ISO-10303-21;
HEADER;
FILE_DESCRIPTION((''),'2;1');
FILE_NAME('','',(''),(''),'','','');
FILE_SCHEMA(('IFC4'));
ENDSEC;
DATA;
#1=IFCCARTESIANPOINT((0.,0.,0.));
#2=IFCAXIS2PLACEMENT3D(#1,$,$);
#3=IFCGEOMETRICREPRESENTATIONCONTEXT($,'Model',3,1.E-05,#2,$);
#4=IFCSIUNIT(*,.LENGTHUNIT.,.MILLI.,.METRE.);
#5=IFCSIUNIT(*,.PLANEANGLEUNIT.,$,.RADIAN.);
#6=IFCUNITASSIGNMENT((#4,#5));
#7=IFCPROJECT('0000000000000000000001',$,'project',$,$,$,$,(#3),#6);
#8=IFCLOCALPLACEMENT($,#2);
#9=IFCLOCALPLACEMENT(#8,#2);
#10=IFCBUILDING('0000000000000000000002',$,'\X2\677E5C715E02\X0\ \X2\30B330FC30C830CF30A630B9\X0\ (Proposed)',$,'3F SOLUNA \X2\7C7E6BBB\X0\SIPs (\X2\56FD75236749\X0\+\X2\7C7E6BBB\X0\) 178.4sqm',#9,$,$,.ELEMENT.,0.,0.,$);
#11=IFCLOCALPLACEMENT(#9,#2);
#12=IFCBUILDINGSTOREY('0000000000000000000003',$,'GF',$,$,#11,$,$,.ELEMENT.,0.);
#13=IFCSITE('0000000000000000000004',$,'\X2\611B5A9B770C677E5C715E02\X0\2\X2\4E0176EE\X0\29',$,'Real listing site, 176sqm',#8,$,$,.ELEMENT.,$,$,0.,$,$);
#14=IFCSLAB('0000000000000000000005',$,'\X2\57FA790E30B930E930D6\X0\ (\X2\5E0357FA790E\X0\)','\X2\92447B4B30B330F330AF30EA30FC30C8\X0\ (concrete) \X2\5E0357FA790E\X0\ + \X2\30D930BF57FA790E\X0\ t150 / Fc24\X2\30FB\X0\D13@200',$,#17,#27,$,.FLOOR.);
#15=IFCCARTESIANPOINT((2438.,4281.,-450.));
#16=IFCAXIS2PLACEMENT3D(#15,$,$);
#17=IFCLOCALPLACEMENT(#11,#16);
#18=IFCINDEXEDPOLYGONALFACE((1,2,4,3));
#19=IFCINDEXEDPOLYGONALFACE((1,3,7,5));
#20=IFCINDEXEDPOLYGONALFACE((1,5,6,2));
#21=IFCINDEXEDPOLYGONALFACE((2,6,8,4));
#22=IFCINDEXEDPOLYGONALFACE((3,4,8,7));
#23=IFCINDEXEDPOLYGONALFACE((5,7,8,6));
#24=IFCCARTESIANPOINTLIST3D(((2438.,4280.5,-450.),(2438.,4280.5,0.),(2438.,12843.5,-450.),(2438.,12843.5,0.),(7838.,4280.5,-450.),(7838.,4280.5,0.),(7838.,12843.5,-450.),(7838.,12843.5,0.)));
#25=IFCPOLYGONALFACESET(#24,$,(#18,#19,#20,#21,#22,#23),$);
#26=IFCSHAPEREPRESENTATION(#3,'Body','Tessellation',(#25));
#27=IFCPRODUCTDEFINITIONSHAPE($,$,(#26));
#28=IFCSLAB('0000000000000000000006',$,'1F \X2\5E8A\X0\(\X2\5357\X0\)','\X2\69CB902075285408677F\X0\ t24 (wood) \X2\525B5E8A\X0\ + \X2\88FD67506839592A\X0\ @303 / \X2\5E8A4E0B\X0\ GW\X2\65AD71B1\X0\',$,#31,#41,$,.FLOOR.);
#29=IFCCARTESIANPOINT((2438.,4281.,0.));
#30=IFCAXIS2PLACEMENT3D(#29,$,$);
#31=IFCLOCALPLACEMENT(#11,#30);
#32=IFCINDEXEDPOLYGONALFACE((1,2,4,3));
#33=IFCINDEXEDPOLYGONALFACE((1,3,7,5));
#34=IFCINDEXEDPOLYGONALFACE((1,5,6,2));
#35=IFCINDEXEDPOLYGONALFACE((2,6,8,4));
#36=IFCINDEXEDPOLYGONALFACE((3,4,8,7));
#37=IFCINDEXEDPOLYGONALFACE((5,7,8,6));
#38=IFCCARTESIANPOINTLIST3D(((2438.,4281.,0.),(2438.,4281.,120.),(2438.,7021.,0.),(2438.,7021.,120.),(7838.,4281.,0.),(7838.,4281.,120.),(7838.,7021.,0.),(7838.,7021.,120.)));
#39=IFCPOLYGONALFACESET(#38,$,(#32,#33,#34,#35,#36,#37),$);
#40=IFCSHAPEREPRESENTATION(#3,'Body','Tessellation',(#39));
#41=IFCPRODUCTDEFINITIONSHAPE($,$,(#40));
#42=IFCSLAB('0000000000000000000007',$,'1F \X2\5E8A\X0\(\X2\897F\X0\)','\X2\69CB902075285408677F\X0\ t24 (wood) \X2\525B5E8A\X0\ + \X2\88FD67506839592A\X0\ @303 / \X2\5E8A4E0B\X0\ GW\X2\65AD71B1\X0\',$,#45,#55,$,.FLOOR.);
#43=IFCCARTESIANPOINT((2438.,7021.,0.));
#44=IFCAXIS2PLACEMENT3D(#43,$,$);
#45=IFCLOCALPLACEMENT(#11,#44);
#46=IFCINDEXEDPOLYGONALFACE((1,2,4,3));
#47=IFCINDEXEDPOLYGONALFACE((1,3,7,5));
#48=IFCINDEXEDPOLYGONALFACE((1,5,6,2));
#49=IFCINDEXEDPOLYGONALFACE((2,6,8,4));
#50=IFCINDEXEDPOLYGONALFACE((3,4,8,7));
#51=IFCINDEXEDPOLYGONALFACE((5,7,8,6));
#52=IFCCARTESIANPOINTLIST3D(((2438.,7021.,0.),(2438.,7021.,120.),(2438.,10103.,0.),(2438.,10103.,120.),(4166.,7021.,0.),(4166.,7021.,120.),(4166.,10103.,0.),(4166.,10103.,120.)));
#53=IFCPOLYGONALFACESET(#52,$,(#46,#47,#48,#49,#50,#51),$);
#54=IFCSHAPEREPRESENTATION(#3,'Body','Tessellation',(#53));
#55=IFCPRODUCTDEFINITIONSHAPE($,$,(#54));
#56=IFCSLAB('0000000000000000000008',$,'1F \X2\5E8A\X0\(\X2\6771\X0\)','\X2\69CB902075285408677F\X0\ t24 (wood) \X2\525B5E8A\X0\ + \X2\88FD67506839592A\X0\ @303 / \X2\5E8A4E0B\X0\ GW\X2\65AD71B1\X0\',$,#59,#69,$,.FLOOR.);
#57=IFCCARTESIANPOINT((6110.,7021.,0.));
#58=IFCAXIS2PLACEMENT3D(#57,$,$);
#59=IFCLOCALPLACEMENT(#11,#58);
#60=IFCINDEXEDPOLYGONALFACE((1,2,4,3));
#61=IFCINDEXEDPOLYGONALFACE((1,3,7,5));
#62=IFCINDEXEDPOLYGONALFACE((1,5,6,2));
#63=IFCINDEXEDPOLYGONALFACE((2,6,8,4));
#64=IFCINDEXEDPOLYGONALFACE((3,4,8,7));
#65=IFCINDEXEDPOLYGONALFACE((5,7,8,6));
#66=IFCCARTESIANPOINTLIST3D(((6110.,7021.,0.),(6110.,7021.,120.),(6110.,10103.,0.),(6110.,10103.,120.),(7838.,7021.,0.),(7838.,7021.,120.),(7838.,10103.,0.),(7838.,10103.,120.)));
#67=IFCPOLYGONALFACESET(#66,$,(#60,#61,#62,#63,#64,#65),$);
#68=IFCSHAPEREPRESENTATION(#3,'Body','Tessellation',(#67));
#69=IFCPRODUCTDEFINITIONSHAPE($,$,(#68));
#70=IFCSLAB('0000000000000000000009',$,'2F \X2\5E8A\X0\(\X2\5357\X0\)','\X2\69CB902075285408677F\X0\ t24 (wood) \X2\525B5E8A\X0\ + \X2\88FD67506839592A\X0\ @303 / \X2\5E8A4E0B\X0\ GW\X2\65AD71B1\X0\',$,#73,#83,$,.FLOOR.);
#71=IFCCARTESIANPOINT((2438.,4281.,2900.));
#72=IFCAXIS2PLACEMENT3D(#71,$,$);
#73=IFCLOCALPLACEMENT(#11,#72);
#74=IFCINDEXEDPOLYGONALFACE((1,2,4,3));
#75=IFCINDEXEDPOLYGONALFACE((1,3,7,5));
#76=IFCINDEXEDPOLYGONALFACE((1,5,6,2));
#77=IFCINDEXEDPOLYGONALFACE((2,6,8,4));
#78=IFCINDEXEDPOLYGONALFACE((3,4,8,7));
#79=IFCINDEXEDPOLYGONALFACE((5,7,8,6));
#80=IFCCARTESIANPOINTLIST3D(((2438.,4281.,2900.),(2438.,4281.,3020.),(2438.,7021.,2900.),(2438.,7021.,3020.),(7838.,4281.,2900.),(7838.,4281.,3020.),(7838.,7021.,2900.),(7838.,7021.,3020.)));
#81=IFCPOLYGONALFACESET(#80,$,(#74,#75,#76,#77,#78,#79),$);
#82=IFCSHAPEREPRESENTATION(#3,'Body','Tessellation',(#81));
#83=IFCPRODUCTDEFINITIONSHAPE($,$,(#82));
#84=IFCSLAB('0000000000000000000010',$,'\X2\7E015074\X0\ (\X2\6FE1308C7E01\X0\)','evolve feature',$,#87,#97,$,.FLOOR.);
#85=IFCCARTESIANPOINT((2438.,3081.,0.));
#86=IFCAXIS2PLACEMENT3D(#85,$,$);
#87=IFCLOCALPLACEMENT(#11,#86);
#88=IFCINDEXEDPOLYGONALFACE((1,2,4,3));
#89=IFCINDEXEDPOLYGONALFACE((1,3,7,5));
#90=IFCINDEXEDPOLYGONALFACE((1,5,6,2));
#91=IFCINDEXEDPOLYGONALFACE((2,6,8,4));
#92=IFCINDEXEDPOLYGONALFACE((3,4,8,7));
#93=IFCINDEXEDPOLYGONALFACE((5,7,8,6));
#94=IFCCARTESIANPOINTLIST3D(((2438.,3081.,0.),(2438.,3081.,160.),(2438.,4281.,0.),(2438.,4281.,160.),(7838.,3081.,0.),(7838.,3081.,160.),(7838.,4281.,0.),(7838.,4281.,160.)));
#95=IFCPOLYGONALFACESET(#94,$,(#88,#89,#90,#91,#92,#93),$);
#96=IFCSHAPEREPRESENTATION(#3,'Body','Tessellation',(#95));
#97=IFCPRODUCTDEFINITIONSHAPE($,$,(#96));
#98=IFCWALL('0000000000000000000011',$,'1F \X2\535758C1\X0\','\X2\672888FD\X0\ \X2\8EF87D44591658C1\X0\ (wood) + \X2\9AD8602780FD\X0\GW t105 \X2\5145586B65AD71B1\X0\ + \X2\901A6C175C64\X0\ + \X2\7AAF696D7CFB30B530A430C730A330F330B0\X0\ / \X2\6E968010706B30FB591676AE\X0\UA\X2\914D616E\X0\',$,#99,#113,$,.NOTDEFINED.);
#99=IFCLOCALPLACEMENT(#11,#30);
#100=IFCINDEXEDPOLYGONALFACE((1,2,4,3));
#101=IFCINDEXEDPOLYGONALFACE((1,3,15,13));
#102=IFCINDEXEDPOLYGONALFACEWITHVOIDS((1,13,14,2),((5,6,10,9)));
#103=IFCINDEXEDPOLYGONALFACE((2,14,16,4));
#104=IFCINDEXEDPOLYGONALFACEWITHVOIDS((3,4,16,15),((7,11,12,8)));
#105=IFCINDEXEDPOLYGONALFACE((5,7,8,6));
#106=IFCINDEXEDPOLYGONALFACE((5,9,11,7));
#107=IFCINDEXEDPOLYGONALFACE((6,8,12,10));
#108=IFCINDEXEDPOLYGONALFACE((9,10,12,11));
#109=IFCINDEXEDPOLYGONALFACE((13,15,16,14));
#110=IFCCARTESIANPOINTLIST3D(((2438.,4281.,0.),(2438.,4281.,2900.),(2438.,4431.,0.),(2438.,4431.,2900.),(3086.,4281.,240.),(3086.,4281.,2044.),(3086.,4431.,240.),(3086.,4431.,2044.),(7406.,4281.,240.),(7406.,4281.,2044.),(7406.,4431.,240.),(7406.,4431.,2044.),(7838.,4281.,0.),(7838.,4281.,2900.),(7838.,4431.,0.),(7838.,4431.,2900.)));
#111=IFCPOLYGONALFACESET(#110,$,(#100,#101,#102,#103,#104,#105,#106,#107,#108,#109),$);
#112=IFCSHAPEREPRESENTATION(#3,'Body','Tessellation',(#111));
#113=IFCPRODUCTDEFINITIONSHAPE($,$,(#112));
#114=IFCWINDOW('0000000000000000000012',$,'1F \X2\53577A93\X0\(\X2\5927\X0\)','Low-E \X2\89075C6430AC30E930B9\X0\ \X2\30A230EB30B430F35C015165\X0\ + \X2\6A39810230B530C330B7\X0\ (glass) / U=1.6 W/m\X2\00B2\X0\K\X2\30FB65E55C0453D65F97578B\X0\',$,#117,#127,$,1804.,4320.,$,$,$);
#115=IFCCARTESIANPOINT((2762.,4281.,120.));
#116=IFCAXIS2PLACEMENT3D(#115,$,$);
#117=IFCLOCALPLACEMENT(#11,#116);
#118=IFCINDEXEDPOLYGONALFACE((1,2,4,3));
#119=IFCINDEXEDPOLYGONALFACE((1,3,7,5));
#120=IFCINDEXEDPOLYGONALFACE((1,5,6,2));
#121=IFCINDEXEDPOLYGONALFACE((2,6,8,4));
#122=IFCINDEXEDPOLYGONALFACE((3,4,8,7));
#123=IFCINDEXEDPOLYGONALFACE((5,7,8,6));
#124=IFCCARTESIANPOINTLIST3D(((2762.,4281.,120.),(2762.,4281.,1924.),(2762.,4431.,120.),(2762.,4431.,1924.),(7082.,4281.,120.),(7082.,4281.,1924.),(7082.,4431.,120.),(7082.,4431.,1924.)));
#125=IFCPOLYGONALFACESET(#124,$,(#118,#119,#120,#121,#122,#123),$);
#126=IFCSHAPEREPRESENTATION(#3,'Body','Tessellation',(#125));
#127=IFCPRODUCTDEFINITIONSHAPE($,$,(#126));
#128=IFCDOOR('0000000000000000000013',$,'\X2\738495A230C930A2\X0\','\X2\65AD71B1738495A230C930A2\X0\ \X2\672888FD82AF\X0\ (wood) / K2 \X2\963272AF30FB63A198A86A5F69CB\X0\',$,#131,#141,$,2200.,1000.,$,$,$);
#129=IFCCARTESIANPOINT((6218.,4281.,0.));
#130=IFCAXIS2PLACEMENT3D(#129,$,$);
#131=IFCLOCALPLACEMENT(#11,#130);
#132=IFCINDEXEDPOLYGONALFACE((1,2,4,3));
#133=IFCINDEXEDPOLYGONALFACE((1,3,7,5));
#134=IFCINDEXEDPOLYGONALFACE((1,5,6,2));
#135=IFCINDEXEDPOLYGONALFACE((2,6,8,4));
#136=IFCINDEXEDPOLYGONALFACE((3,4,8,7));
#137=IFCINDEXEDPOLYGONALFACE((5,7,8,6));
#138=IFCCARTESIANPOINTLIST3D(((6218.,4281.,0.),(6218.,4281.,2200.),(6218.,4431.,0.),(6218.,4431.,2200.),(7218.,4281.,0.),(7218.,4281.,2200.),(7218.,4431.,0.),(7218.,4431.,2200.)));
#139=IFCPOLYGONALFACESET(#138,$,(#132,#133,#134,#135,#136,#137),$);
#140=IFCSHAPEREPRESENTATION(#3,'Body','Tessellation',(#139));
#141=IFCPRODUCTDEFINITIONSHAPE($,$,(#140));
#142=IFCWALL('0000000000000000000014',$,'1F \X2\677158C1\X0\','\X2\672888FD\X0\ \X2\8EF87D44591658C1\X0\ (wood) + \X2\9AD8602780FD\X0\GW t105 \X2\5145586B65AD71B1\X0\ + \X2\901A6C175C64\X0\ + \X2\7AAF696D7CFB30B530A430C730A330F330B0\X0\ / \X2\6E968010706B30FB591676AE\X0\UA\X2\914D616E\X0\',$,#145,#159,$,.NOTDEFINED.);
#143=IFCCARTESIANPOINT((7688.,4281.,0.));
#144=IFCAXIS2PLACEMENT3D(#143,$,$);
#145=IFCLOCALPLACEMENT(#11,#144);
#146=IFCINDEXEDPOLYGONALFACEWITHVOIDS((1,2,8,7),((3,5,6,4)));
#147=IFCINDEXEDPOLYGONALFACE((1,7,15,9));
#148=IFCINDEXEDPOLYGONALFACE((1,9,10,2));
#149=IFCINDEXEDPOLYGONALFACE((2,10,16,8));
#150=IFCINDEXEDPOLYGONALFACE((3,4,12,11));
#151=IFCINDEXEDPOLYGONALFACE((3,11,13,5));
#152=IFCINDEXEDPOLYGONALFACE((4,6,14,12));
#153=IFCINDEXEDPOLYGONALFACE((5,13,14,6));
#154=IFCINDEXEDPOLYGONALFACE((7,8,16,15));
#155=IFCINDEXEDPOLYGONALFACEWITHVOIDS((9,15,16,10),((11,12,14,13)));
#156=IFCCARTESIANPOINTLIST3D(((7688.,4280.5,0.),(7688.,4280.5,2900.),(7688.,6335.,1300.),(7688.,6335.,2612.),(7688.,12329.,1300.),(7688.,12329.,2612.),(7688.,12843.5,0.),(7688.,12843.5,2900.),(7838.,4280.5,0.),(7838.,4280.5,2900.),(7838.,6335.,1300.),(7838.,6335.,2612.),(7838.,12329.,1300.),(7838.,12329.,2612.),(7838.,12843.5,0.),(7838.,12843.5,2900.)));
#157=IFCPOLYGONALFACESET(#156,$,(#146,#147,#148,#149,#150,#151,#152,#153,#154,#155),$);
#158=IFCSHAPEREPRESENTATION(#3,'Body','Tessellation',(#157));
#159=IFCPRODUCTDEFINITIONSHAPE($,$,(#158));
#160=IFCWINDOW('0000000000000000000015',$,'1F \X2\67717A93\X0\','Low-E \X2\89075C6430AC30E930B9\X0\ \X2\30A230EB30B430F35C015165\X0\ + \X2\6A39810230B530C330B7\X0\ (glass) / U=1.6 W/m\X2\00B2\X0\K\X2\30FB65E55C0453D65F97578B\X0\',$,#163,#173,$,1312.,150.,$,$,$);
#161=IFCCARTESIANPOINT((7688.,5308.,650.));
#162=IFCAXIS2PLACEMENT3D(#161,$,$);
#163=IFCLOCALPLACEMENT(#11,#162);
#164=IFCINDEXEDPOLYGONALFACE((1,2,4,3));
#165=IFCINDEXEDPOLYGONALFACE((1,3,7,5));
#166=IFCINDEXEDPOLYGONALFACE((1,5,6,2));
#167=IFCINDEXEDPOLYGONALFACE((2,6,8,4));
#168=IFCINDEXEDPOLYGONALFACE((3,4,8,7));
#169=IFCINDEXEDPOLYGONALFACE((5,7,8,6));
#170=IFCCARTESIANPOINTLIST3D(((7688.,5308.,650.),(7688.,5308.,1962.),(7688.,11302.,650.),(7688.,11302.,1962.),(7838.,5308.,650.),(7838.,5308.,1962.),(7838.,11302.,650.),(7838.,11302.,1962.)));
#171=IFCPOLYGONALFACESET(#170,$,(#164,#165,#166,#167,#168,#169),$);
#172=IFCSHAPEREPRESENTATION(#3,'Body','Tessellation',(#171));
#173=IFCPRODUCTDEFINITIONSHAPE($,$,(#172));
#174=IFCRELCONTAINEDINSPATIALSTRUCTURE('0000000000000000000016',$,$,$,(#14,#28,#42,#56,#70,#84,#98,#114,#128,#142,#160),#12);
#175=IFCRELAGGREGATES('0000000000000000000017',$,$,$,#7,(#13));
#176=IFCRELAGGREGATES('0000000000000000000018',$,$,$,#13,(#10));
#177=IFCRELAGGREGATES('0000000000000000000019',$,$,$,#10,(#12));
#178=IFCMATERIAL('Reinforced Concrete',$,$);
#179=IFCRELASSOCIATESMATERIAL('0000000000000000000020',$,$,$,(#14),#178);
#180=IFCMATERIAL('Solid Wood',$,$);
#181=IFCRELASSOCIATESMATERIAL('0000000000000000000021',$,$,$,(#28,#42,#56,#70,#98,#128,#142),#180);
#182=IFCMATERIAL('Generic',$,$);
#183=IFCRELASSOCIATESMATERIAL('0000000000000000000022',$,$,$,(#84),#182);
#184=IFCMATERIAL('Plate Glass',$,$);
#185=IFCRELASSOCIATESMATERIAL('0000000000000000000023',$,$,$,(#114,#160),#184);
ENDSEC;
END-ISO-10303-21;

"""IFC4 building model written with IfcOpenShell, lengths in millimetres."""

from ifc_helpers import new_model, si_unit, frame, frame_2d, origin, place, context, project, spatial, rectangle, extrude, material, element, fill, save


model = new_model("IFC4")

# Units and contexts
model_context = context("Model", 3, precision=1e-05, world=origin())
ifc_project = project(units=[si_unit("LENGTHUNIT", "METRE", prefix="MILLI"), si_unit("PLANEANGLEUNIT", "RADIAN")], contexts=[model_context])

# Site, building, storey
site_placement = place(None, origin())
site = spatial("IfcSite", under=ifc_project, at=site_placement, Name="愛媛県松山市2丁目29", ObjectType="Real listing site, 176sqm", CompositionType="ELEMENT", RefElevation=0.0)
building_placement = place(site_placement, origin())
building = spatial("IfcBuilding", under=site, at=building_placement, Name="松山市 コートハウス (Proposed)", ObjectType="3F SOLUNA 籾殻SIPs (国産杉+籾殻) 178.4sqm", CompositionType="ELEMENT", ElevationOfRefHeight=0.0, ElevationOfTerrain=0.0)
storey_placement = place(building_placement, origin())
storey = spatial("IfcBuildingStorey", under=building, at=storey_placement, Name="GF", CompositionType="ELEMENT", Elevation=0.0)

# Slabs
ifc_material_1 = material(Name="Reinforced Concrete")
slab_1_placement = place(storey_placement, frame((2438.0, 4281.0, -450.0)))
element("IfcSlab", 1, at=slab_1_placement, inside=storey, material=ifc_material_1, Name="基礎スラブ (布基礎)", Description="鉄筋コンクリート (concrete) 布基礎 + ベタ基礎 t150 / Fc24・D13@200", PredefinedType="FLOOR", context=model_context, shape_type="SweptSolid", body=[
    extrude(rectangle(XDim=5400.0, YDim=8563.0, at=frame_2d((2700.0, 4281.0))), frame((2438.0, 4281.0, -450.0)), (0.0, 0.0, 1.0), 450.0),
])
ifc_material_2 = material(Name="Solid Wood")
slab_2_placement = place(storey_placement, frame((2438.0, 4281.0, 0.0)))
element("IfcSlab", 2, at=slab_2_placement, inside=storey, material=ifc_material_2, Name="1F 床(南)", Description="構造用合板 t24 (wood) 剛床 + 製材根太 @303 / 床下 GW断熱", PredefinedType="FLOOR", context=model_context, shape_type="SweptSolid", body=[
    extrude(rectangle(XDim=5400.0, YDim=2740.0, at=frame_2d((2700.0, 1370.0))), frame((2438.0, 4281.0, 0.0)), (0.0, 0.0, 1.0), 120.0),
])
slab_3_placement = place(storey_placement, frame((2438.0, 7021.0, 0.0)))
element("IfcSlab", 3, at=slab_3_placement, inside=storey, material=ifc_material_2, Name="1F 床(西)", Description="構造用合板 t24 (wood) 剛床 + 製材根太 @303 / 床下 GW断熱", PredefinedType="FLOOR", context=model_context, shape_type="SweptSolid", body=[
    extrude(rectangle(XDim=1728.0, YDim=3082.0, at=frame_2d((864.0, 1541.0))), frame((2438.0, 7021.0, 0.0)), (0.0, 0.0, 1.0), 120.0),
])
slab_4_placement = place(storey_placement, frame((6110.0, 7021.0, 0.0)))
element("IfcSlab", 4, at=slab_4_placement, inside=storey, material=ifc_material_2, Name="1F 床(東)", Description="構造用合板 t24 (wood) 剛床 + 製材根太 @303 / 床下 GW断熱", PredefinedType="FLOOR", context=model_context, shape_type="SweptSolid", body=[
    extrude(rectangle(XDim=1728.0, YDim=3082.0, at=frame_2d((864.0, 1541.0))), frame((6110.0, 7021.0, 0.0)), (0.0, 0.0, 1.0), 120.0),
])
slab_5_placement = place(storey_placement, frame((2438.0, 4281.0, 2900.0)))
element("IfcSlab", 5, at=slab_5_placement, inside=storey, material=ifc_material_2, Name="2F 床(南)", Description="構造用合板 t24 (wood) 剛床 + 製材根太 @303 / 床下 GW断熱", PredefinedType="FLOOR", context=model_context, shape_type="SweptSolid", body=[
    extrude(rectangle(XDim=5400.0, YDim=2740.0, at=frame_2d((2700.0, 1370.0))), frame((2438.0, 4281.0, 2900.0)), (0.0, 0.0, 1.0), 120.0),
])
ifc_material_3 = material(Name="Generic")
slab_6_placement = place(storey_placement, frame((2438.0, 3081.0, 0.0)))
element("IfcSlab", 6, at=slab_6_placement, inside=storey, material=ifc_material_3, Name="縁側 (濡れ縁)", Description="evolve feature", PredefinedType="FLOOR", context=model_context, shape_type="SweptSolid", body=[
    extrude(rectangle(XDim=5400.0, YDim=1200.0, at=frame_2d((2700.0, 600.0))), frame((2438.0, 3081.0, 0.0)), (0.0, 0.0, 1.0), 160.0),
])

# Wall, openings, window, door
wall_1_placement = place(storey_placement, frame((2438.0, 4281.0, 0.0)))
wall_1 = element("IfcWall", 7, at=wall_1_placement, inside=storey, material=ifc_material_2, Name="1F 南壁", Description="木製 軸組外壁 (wood) + 高性能GW t105 充填断熱 + 通気層 + 窯業系サイディング / 準耐火・外皮UA配慮", PredefinedType="NOTDEFINED", context=model_context, shape_type="SweptSolid", body=[
    extrude(rectangle(XDim=5400.0, YDim=150.0, at=frame_2d((2700.0, 75.0))), frame((2438.0, 4281.0, 0.0)), (0.0, 0.0, 1.0), 2900.0),
])
opening_1_placement = place(storey_placement, frame((2762.0, 4281.0, 120.0)))
opening_1 = element("IfcOpeningElement", 8, at=opening_1_placement, cuts=wall_1, PredefinedType="NOTDEFINED", context=model_context, shape_type="SweptSolid", body=[
    extrude(rectangle(XDim=4320.0, YDim=150.0, at=frame_2d((2160.0, 75.0))), frame((2762.0, 4281.0, 120.0)), (0.0, 0.0, 1.0), 1804.0),
])
opening_2_placement = place(storey_placement, frame((6218.0, 4281.0, 0.0)))
opening_2 = element("IfcOpeningElement", 9, at=opening_2_placement, cuts=wall_1, PredefinedType="NOTDEFINED", context=model_context, shape_type="SweptSolid", body=[
    extrude(rectangle(XDim=1000.0, YDim=150.0, at=frame_2d((500.0, 75.0))), frame((6218.0, 4281.0, 0.0)), (0.0, 0.0, 1.0), 2200.0),
])
ifc_material_4 = material(Name="Plate Glass")
window_1_placement = place(storey_placement, frame((2762.0, 4281.0, 120.0)))
window_1 = element("IfcWindow", 10, at=window_1_placement, inside=storey, material=ifc_material_4, Name="1F 南窓(大)", Description="Low-E 複層ガラス アルゴン封入 + 樹脂サッシ (glass) / U=1.6 W/m²K・日射取得型", OverallHeight=1804.0, OverallWidth=4320.0, context=model_context, shape_type="SweptSolid", body=[
    extrude(rectangle(XDim=4320.0, YDim=150.0, at=frame_2d((2160.0, 75.0))), frame((2762.0, 4281.0, 120.0)), (0.0, 0.0, 1.0), 1804.0),
])
fill(opening_1, window_1)
door_placement = place(storey_placement, frame((6218.0, 4281.0, 0.0)))
door = element("IfcDoor", 11, at=door_placement, inside=storey, material=ifc_material_2, Name="玄関ドア", Description="断熱玄関ドア 木製芯 (wood) / K2 防犯・採風機構", OverallHeight=2200.0, OverallWidth=1000.0, context=model_context, shape_type="SweptSolid", body=[
    extrude(rectangle(XDim=1000.0, YDim=150.0, at=frame_2d((500.0, 75.0))), frame((6218.0, 4281.0, 0.0)), (0.0, 0.0, 1.0), 2200.0),
])
fill(opening_2, door)

# Wall, opening, window
wall_2_placement = place(storey_placement, frame((7688.0, 4281.0, 0.0)))
wall_2 = element("IfcWall", 12, at=wall_2_placement, inside=storey, material=ifc_material_2, Name="1F 東壁", Description="木製 軸組外壁 (wood) + 高性能GW t105 充填断熱 + 通気層 + 窯業系サイディング / 準耐火・外皮UA配慮", PredefinedType="NOTDEFINED", context=model_context, shape_type="SweptSolid", body=[
    extrude(rectangle(XDim=150.0, YDim=8563.0, at=frame_2d((75.0, 4281.0))), frame((7688.0, 4281.0, 0.0)), (0.0, 0.0, 1.0), 2900.0),
])
opening_3_placement = place(storey_placement, frame((7688.0, 5308.0, 650.0)))
opening_3 = element("IfcOpeningElement", 13, at=opening_3_placement, cuts=wall_2, PredefinedType="NOTDEFINED", context=model_context, shape_type="SweptSolid", body=[
    extrude(rectangle(XDim=150.0, YDim=5994.0, at=frame_2d((75.0, 2997.0))), frame((7688.0, 5308.0, 650.0)), (0.0, 0.0, 1.0), 1312.0),
])
window_2_placement = place(storey_placement, frame((7688.0, 5308.0, 650.0)))
window_2 = element("IfcWindow", 14, at=window_2_placement, inside=storey, material=ifc_material_4, Name="1F 東窓", Description="Low-E 複層ガラス アルゴン封入 + 樹脂サッシ (glass) / U=1.6 W/m²K・日射取得型", OverallHeight=1312.0, OverallWidth=150.0, context=model_context, shape_type="SweptSolid", body=[
    extrude(rectangle(XDim=150.0, YDim=5994.0, at=frame_2d((75.0, 2997.0))), frame((7688.0, 5308.0, 650.0)), (0.0, 0.0, 1.0), 1312.0),
])
fill(opening_3, window_2)

save(model, "model.ifc")
